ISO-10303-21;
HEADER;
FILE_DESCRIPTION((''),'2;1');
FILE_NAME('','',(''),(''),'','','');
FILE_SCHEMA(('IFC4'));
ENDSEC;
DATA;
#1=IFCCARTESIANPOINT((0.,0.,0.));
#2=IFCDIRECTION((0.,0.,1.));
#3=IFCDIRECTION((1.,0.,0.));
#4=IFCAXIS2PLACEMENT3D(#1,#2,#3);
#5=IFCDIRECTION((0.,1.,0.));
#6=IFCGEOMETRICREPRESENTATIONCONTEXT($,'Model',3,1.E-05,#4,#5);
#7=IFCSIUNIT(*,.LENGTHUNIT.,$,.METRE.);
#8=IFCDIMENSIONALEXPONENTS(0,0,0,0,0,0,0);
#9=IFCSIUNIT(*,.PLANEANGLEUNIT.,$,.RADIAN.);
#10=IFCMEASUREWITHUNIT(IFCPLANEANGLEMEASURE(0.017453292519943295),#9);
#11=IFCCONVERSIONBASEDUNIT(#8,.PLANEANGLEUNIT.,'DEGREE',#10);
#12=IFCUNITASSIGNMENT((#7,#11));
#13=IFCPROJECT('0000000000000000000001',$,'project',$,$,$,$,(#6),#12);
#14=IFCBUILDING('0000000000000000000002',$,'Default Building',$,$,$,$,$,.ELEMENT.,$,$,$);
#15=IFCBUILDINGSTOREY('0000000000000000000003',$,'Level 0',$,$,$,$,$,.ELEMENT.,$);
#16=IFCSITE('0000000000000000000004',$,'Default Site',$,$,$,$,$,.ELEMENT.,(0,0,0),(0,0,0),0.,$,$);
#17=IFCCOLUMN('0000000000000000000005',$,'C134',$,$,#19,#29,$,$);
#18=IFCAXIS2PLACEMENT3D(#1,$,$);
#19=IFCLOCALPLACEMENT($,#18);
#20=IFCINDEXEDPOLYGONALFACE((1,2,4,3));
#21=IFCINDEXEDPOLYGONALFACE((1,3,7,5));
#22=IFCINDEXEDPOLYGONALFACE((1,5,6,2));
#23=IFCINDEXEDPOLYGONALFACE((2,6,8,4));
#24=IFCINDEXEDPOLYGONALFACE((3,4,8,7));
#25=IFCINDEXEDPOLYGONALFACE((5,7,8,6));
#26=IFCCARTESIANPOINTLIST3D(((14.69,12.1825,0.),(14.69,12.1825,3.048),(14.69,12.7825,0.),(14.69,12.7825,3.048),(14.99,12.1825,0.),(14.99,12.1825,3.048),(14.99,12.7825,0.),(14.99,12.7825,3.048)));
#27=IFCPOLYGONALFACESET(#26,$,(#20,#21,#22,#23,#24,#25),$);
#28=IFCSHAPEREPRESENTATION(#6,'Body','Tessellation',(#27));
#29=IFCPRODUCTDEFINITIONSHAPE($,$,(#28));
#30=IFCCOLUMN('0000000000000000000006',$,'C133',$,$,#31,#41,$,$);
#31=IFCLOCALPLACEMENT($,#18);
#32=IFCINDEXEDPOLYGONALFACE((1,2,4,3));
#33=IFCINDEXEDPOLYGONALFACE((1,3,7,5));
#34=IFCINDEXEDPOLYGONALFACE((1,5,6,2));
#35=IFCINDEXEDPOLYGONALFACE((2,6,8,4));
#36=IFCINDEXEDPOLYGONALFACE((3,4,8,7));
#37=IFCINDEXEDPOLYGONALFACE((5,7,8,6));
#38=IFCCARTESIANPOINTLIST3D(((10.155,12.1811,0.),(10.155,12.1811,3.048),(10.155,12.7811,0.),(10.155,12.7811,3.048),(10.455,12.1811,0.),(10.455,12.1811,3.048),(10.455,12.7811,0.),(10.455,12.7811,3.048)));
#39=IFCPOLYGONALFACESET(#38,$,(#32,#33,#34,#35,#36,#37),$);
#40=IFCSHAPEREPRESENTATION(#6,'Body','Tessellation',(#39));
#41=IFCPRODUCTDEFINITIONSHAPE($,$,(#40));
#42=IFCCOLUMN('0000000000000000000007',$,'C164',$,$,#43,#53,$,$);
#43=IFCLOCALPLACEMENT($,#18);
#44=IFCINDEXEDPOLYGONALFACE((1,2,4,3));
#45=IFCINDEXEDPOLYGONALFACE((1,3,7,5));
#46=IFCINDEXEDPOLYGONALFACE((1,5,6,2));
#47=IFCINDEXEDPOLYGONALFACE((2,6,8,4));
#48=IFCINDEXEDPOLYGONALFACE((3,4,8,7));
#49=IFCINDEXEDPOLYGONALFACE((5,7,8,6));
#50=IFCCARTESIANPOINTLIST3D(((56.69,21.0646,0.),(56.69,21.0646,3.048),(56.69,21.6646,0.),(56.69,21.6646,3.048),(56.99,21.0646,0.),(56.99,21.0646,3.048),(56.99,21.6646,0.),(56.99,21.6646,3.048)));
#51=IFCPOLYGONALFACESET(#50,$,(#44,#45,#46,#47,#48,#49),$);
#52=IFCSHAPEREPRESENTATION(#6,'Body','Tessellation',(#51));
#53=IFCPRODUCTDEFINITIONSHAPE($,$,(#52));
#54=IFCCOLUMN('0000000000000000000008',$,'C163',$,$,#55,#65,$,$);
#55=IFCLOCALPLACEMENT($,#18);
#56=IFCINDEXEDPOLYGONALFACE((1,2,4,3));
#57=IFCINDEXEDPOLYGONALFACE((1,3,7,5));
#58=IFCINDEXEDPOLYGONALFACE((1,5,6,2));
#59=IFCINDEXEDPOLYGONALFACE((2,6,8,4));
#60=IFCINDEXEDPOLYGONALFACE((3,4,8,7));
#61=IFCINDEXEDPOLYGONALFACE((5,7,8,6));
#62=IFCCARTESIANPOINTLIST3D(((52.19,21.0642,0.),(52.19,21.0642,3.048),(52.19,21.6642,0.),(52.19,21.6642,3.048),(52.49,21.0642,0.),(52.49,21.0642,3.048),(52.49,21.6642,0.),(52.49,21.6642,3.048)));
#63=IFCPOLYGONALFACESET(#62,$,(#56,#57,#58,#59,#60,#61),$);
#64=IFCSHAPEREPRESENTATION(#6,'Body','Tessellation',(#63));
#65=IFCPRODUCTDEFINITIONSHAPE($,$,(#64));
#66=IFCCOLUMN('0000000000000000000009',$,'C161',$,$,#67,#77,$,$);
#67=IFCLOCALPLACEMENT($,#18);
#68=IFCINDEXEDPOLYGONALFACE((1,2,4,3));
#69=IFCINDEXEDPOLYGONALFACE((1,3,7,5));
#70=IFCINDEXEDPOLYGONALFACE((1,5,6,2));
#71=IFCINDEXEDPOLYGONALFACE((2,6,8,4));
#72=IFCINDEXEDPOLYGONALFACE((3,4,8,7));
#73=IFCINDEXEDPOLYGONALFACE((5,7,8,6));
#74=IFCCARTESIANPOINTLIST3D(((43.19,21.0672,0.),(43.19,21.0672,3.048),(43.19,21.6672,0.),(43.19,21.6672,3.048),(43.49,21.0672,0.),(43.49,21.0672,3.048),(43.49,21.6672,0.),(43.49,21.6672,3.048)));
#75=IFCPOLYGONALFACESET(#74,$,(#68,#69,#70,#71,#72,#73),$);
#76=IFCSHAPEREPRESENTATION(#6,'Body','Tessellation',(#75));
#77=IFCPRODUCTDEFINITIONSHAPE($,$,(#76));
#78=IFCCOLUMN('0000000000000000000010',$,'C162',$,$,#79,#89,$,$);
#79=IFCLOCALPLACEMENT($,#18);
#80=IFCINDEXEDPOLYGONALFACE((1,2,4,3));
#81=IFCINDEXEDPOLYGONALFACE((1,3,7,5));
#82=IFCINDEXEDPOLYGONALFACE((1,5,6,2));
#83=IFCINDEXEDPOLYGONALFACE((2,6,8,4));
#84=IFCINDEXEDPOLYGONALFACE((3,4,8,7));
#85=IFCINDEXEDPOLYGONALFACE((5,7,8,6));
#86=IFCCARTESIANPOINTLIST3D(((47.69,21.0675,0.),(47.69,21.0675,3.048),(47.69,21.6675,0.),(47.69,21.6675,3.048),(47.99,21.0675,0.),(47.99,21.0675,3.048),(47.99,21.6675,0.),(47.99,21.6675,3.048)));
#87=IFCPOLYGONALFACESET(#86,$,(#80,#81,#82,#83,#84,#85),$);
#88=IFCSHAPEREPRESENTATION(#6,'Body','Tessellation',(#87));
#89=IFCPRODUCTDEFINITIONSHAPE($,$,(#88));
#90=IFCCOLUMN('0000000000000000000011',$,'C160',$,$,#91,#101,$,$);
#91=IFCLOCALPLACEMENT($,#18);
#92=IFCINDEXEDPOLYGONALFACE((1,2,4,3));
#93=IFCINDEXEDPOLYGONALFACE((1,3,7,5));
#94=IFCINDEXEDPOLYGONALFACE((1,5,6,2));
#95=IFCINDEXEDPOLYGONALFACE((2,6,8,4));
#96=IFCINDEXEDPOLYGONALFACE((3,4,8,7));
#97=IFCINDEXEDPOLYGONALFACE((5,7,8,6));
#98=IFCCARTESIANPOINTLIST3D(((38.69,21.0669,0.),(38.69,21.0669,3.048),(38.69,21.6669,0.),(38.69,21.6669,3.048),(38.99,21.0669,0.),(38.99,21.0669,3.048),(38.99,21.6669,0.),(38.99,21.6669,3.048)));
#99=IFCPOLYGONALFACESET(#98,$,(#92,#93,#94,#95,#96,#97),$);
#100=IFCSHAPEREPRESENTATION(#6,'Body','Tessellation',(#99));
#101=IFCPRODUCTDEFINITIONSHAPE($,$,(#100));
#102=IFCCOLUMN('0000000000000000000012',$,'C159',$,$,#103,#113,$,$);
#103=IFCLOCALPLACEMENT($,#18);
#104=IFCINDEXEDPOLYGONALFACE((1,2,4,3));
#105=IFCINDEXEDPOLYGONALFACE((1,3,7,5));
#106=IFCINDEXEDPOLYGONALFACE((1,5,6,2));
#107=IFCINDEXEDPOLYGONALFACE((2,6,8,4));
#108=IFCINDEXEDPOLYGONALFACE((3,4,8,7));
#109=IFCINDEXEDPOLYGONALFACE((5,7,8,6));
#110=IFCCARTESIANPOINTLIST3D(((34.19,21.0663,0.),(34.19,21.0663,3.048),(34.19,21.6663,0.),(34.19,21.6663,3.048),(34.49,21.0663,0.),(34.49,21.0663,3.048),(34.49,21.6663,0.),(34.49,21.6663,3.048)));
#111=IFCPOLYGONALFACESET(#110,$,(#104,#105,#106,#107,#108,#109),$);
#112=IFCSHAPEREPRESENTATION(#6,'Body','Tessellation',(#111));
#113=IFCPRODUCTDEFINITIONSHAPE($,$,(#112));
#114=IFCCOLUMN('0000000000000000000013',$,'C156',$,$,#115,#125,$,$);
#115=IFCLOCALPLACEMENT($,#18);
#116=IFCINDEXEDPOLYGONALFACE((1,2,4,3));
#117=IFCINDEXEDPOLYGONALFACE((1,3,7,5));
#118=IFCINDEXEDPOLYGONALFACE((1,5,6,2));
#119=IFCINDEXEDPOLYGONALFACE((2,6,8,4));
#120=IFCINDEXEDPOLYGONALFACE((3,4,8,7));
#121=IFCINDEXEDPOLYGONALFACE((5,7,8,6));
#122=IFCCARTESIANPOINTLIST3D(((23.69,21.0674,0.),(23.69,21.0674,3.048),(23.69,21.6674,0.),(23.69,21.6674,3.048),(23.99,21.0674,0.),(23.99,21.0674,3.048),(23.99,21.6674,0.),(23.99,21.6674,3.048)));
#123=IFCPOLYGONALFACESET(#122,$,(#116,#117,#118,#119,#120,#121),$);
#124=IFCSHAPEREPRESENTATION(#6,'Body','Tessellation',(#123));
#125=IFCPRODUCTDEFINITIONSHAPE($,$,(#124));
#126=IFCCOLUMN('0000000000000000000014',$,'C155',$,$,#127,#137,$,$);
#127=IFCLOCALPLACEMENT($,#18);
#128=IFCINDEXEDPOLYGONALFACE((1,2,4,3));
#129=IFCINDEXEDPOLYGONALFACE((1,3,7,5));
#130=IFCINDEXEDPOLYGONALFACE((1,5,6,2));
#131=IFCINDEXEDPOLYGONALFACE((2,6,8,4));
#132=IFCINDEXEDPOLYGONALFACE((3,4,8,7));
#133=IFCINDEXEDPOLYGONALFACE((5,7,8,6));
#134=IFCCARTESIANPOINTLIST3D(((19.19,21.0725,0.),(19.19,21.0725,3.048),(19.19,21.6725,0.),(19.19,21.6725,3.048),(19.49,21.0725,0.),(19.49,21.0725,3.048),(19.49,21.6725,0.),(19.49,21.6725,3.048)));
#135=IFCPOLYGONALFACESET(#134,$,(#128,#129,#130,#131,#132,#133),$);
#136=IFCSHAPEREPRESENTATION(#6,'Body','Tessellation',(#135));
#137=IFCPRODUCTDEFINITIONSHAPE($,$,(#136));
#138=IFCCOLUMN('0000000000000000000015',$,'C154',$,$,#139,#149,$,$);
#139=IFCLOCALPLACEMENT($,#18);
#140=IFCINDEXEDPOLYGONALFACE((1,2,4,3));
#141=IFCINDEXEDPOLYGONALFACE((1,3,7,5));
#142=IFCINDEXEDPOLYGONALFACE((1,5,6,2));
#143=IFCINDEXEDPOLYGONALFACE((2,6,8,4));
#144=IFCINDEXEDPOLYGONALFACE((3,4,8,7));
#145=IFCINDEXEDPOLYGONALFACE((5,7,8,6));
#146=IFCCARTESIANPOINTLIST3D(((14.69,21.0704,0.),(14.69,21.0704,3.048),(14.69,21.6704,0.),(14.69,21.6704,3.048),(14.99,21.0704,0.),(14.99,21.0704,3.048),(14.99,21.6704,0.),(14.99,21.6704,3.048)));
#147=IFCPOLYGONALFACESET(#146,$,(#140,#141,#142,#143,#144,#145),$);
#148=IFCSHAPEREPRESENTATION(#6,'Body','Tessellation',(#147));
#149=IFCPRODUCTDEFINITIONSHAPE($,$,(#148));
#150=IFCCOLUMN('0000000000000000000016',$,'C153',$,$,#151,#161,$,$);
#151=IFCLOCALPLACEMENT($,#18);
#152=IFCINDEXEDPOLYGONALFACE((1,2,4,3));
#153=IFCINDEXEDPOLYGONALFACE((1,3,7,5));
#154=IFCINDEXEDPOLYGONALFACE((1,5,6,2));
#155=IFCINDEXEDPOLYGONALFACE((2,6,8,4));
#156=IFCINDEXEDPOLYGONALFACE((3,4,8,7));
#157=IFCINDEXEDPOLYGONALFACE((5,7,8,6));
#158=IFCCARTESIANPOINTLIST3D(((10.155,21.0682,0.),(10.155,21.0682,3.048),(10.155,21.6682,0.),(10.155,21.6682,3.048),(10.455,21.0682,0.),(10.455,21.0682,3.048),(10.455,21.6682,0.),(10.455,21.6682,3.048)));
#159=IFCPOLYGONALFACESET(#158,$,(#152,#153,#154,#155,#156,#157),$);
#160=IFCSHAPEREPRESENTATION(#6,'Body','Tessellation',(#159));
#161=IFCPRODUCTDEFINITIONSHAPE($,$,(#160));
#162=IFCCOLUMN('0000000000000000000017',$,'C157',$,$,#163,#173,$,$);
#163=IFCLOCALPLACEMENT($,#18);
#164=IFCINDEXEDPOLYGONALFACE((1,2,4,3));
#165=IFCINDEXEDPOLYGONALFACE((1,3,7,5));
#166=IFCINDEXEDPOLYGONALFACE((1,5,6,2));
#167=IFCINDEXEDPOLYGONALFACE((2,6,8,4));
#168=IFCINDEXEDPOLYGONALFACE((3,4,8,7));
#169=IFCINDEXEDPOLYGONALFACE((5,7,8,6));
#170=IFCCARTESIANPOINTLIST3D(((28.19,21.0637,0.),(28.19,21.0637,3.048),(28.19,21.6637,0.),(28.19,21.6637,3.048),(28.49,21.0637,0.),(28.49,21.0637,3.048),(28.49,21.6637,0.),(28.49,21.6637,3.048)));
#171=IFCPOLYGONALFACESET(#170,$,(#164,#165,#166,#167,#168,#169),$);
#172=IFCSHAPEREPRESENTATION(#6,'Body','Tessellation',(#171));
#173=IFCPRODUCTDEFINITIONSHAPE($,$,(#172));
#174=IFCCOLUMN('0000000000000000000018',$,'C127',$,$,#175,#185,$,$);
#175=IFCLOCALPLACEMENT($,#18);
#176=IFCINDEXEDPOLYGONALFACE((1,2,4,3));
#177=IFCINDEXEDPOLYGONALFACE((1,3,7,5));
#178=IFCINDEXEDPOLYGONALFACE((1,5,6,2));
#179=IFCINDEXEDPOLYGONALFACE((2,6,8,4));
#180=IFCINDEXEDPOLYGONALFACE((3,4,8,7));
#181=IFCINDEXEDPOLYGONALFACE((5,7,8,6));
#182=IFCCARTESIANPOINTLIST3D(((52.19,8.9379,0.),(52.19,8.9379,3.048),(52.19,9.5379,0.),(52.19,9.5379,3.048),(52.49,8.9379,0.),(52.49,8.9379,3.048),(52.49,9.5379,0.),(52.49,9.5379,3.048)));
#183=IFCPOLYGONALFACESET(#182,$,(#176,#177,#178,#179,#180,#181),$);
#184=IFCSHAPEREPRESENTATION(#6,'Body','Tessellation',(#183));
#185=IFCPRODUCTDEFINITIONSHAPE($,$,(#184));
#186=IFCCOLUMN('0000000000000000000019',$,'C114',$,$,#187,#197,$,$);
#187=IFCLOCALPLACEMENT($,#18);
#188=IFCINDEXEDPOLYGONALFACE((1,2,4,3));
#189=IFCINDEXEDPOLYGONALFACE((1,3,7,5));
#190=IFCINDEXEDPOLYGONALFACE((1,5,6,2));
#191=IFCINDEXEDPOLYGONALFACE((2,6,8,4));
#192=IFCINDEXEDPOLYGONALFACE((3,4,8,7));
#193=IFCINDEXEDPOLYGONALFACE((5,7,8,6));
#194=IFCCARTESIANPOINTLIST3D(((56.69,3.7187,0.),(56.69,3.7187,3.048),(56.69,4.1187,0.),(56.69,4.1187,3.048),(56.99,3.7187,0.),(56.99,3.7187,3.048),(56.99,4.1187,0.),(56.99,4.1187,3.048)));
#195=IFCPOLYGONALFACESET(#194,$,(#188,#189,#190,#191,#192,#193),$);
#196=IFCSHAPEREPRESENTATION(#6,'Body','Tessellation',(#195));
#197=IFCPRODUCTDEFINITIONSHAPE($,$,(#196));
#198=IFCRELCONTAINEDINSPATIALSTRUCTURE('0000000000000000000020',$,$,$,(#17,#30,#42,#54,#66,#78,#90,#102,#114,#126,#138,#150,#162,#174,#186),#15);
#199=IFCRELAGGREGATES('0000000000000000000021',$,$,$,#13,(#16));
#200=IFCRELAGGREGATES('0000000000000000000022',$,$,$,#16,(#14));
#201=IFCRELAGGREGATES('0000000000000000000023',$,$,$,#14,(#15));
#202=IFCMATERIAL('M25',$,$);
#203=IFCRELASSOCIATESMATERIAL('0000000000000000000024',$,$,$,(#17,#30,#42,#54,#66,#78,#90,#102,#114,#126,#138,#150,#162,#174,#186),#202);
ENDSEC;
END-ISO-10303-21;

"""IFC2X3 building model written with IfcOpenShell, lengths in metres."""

from ifc_helpers import new_model, entity, si_unit, converted_unit, direction, frame, frame_2d, origin_with_axes, place, context, project, spatial, rectangle, extrude, material, element, save


model = new_model("IFC2X3")

# Units and contexts
model_context = context("Model", 3, precision=1e-05, world=origin_with_axes(), true_north=direction((0.0, 1.0, 0.0)))
ifc_project = project(units=[si_unit("LENGTHUNIT", "METRE"), converted_unit("PLANEANGLEUNIT", "DEGREE", entity("IfcPlaneAngleMeasure", 0.017453292519943295), si_unit("PLANEANGLEUNIT", "RADIAN"), dimensions=[0, 0, 0, 0, 0, 0, 0])], contexts=[model_context])

# Site, building, storey
site = spatial("IfcSite", under=ifc_project, Name="Default Site", CompositionType="ELEMENT", RefLatitude=(0, 0, 0), RefLongitude=(0, 0, 0), RefElevation=0.0)
building = spatial("IfcBuilding", under=site, Name="Default Building", CompositionType="ELEMENT")
storey = spatial("IfcBuildingStorey", under=building, Name="Level 0", CompositionType="ELEMENT")

# Columns
ifc_material = material(Name="M25")
placement = place(None, origin_with_axes())
element("IfcColumn", 1, at=placement, inside=storey, material=ifc_material, Name="C134", context=model_context, shape_type="SweptSolid", body=[
    extrude(rectangle(XDim=0.3, YDim=0.6, at=frame_2d((0.0, 0.0), x_axis=(1.0, 0.0, 0.0))), frame((14.84, 12.4825, 0.0), z_axis=(0.0, 0.0, 1.0), x_axis=(1.0, 0.0, 0.0)), (0.0, 0.0, 1.0), 3.048),
])
element("IfcColumn", 2, at=placement, inside=storey, material=ifc_material, Name="C133", context=model_context, shape_type="SweptSolid", body=[
    extrude(rectangle(XDim=0.3, YDim=0.6, at=frame_2d((0.0, 0.0), x_axis=(1.0, 0.0, 0.0))), frame((10.305, 12.4811, 0.0), z_axis=(0.0, 0.0, 1.0), x_axis=(1.0, 0.0, 0.0)), (0.0, 0.0, 1.0), 3.048),
])
element("IfcColumn", 3, at=placement, inside=storey, material=ifc_material, Name="C164", context=model_context, shape_type="SweptSolid", body=[
    extrude(rectangle(XDim=0.3, YDim=0.6, at=frame_2d((0.0, 0.0), x_axis=(1.0, 0.0, 0.0))), frame((56.84, 21.3646, 0.0), z_axis=(0.0, 0.0, 1.0), x_axis=(1.0, 0.0, 0.0)), (0.0, 0.0, 1.0), 3.048),
])
element("IfcColumn", 4, at=placement, inside=storey, material=ifc_material, Name="C163", context=model_context, shape_type="SweptSolid", body=[
    extrude(rectangle(XDim=0.3, YDim=0.6, at=frame_2d((0.0, 0.0), x_axis=(1.0, 0.0, 0.0))), frame((52.34, 21.3642, 0.0), z_axis=(0.0, 0.0, 1.0), x_axis=(1.0, 0.0, 0.0)), (0.0, 0.0, 1.0), 3.048),
])
element("IfcColumn", 5, at=placement, inside=storey, material=ifc_material, Name="C161", context=model_context, shape_type="SweptSolid", body=[
    extrude(rectangle(XDim=0.3, YDim=0.6, at=frame_2d((0.0, 0.0), x_axis=(1.0, 0.0, 0.0))), frame((43.34, 21.3672, 0.0), z_axis=(0.0, 0.0, 1.0), x_axis=(1.0, 0.0, 0.0)), (0.0, 0.0, 1.0), 3.048),
])
element("IfcColumn", 6, at=placement, inside=storey, material=ifc_material, Name="C162", context=model_context, shape_type="SweptSolid", body=[
    extrude(rectangle(XDim=0.3, YDim=0.6, at=frame_2d((0.0, 0.0), x_axis=(1.0, 0.0, 0.0))), frame((47.84, 21.3675, 0.0), z_axis=(0.0, 0.0, 1.0), x_axis=(1.0, 0.0, 0.0)), (0.0, 0.0, 1.0), 3.048),
])
element("IfcColumn", 7, at=placement, inside=storey, material=ifc_material, Name="C160", context=model_context, shape_type="SweptSolid", body=[
    extrude(rectangle(XDim=0.3, YDim=0.6, at=frame_2d((0.0, 0.0), x_axis=(1.0, 0.0, 0.0))), frame((38.84, 21.3669, 0.0), z_axis=(0.0, 0.0, 1.0), x_axis=(1.0, 0.0, 0.0)), (0.0, 0.0, 1.0), 3.048),
])
element("IfcColumn", 8, at=placement, inside=storey, material=ifc_material, Name="C159", context=model_context, shape_type="SweptSolid", body=[
    extrude(rectangle(XDim=0.3, YDim=0.6, at=frame_2d((0.0, 0.0), x_axis=(1.0, 0.0, 0.0))), frame((34.34, 21.3663, 0.0), z_axis=(0.0, 0.0, 1.0), x_axis=(1.0, 0.0, 0.0)), (0.0, 0.0, 1.0), 3.048),
])
element("IfcColumn", 9, at=placement, inside=storey, material=ifc_material, Name="C156", context=model_context, shape_type="SweptSolid", body=[
    extrude(rectangle(XDim=0.3, YDim=0.6, at=frame_2d((0.0, 0.0), x_axis=(1.0, 0.0, 0.0))), frame((23.84, 21.3674, 0.0), z_axis=(0.0, 0.0, 1.0), x_axis=(1.0, 0.0, 0.0)), (0.0, 0.0, 1.0), 3.048),
])
element("IfcColumn", 10, at=placement, inside=storey, material=ifc_material, Name="C155", context=model_context, shape_type="SweptSolid", body=[
    extrude(rectangle(XDim=0.3, YDim=0.6, at=frame_2d((0.0, 0.0), x_axis=(1.0, 0.0, 0.0))), frame((19.34, 21.3725, 0.0), z_axis=(0.0, 0.0, 1.0), x_axis=(1.0, 0.0, 0.0)), (0.0, 0.0, 1.0), 3.048),
])
element("IfcColumn", 11, at=placement, inside=storey, material=ifc_material, Name="C154", context=model_context, shape_type="SweptSolid", body=[
    extrude(rectangle(XDim=0.3, YDim=0.6, at=frame_2d((0.0, 0.0), x_axis=(1.0, 0.0, 0.0))), frame((14.84, 21.3704, 0.0), z_axis=(0.0, 0.0, 1.0), x_axis=(1.0, 0.0, 0.0)), (0.0, 0.0, 1.0), 3.048),
])
element("IfcColumn", 12, at=placement, inside=storey, material=ifc_material, Name="C153", context=model_context, shape_type="SweptSolid", body=[
    extrude(rectangle(XDim=0.3, YDim=0.6, at=frame_2d((0.0, 0.0), x_axis=(1.0, 0.0, 0.0))), frame((10.305, 21.3682, 0.0), z_axis=(0.0, 0.0, 1.0), x_axis=(1.0, 0.0, 0.0)), (0.0, 0.0, 1.0), 3.048),
])
element("IfcColumn", 13, at=placement, inside=storey, material=ifc_material, Name="C157", context=model_context, shape_type="SweptSolid", body=[
    extrude(rectangle(XDim=0.3, YDim=0.6, at=frame_2d((0.0, 0.0), x_axis=(1.0, 0.0, 0.0))), frame((28.34, 21.3637, 0.0), z_axis=(0.0, 0.0, 1.0), x_axis=(1.0, 0.0, 0.0)), (0.0, 0.0, 1.0), 3.048),
])
element("IfcColumn", 14, at=placement, inside=storey, material=ifc_material, Name="C127", context=model_context, shape_type="SweptSolid", body=[
    extrude(rectangle(XDim=0.3, YDim=0.6, at=frame_2d((0.0, 0.0), x_axis=(1.0, 0.0, 0.0))), frame((52.34, 9.2379, 0.0), z_axis=(0.0, 0.0, 1.0), x_axis=(1.0, 0.0, 0.0)), (0.0, 0.0, 1.0), 3.048),
])
element("IfcColumn", 15, at=placement, inside=storey, material=ifc_material, Name="C114", context=model_context, shape_type="SweptSolid", body=[
    extrude(rectangle(XDim=0.3, YDim=0.4, at=frame_2d((0.0, 0.0), x_axis=(1.0, 0.0, 0.0))), frame((56.84, 3.9187, 0.0), z_axis=(0.0, 0.0, 1.0), x_axis=(1.0, 0.0, 0.0)), (0.0, 0.0, 1.0), 3.048),
])

save(model, "model.ifc")
